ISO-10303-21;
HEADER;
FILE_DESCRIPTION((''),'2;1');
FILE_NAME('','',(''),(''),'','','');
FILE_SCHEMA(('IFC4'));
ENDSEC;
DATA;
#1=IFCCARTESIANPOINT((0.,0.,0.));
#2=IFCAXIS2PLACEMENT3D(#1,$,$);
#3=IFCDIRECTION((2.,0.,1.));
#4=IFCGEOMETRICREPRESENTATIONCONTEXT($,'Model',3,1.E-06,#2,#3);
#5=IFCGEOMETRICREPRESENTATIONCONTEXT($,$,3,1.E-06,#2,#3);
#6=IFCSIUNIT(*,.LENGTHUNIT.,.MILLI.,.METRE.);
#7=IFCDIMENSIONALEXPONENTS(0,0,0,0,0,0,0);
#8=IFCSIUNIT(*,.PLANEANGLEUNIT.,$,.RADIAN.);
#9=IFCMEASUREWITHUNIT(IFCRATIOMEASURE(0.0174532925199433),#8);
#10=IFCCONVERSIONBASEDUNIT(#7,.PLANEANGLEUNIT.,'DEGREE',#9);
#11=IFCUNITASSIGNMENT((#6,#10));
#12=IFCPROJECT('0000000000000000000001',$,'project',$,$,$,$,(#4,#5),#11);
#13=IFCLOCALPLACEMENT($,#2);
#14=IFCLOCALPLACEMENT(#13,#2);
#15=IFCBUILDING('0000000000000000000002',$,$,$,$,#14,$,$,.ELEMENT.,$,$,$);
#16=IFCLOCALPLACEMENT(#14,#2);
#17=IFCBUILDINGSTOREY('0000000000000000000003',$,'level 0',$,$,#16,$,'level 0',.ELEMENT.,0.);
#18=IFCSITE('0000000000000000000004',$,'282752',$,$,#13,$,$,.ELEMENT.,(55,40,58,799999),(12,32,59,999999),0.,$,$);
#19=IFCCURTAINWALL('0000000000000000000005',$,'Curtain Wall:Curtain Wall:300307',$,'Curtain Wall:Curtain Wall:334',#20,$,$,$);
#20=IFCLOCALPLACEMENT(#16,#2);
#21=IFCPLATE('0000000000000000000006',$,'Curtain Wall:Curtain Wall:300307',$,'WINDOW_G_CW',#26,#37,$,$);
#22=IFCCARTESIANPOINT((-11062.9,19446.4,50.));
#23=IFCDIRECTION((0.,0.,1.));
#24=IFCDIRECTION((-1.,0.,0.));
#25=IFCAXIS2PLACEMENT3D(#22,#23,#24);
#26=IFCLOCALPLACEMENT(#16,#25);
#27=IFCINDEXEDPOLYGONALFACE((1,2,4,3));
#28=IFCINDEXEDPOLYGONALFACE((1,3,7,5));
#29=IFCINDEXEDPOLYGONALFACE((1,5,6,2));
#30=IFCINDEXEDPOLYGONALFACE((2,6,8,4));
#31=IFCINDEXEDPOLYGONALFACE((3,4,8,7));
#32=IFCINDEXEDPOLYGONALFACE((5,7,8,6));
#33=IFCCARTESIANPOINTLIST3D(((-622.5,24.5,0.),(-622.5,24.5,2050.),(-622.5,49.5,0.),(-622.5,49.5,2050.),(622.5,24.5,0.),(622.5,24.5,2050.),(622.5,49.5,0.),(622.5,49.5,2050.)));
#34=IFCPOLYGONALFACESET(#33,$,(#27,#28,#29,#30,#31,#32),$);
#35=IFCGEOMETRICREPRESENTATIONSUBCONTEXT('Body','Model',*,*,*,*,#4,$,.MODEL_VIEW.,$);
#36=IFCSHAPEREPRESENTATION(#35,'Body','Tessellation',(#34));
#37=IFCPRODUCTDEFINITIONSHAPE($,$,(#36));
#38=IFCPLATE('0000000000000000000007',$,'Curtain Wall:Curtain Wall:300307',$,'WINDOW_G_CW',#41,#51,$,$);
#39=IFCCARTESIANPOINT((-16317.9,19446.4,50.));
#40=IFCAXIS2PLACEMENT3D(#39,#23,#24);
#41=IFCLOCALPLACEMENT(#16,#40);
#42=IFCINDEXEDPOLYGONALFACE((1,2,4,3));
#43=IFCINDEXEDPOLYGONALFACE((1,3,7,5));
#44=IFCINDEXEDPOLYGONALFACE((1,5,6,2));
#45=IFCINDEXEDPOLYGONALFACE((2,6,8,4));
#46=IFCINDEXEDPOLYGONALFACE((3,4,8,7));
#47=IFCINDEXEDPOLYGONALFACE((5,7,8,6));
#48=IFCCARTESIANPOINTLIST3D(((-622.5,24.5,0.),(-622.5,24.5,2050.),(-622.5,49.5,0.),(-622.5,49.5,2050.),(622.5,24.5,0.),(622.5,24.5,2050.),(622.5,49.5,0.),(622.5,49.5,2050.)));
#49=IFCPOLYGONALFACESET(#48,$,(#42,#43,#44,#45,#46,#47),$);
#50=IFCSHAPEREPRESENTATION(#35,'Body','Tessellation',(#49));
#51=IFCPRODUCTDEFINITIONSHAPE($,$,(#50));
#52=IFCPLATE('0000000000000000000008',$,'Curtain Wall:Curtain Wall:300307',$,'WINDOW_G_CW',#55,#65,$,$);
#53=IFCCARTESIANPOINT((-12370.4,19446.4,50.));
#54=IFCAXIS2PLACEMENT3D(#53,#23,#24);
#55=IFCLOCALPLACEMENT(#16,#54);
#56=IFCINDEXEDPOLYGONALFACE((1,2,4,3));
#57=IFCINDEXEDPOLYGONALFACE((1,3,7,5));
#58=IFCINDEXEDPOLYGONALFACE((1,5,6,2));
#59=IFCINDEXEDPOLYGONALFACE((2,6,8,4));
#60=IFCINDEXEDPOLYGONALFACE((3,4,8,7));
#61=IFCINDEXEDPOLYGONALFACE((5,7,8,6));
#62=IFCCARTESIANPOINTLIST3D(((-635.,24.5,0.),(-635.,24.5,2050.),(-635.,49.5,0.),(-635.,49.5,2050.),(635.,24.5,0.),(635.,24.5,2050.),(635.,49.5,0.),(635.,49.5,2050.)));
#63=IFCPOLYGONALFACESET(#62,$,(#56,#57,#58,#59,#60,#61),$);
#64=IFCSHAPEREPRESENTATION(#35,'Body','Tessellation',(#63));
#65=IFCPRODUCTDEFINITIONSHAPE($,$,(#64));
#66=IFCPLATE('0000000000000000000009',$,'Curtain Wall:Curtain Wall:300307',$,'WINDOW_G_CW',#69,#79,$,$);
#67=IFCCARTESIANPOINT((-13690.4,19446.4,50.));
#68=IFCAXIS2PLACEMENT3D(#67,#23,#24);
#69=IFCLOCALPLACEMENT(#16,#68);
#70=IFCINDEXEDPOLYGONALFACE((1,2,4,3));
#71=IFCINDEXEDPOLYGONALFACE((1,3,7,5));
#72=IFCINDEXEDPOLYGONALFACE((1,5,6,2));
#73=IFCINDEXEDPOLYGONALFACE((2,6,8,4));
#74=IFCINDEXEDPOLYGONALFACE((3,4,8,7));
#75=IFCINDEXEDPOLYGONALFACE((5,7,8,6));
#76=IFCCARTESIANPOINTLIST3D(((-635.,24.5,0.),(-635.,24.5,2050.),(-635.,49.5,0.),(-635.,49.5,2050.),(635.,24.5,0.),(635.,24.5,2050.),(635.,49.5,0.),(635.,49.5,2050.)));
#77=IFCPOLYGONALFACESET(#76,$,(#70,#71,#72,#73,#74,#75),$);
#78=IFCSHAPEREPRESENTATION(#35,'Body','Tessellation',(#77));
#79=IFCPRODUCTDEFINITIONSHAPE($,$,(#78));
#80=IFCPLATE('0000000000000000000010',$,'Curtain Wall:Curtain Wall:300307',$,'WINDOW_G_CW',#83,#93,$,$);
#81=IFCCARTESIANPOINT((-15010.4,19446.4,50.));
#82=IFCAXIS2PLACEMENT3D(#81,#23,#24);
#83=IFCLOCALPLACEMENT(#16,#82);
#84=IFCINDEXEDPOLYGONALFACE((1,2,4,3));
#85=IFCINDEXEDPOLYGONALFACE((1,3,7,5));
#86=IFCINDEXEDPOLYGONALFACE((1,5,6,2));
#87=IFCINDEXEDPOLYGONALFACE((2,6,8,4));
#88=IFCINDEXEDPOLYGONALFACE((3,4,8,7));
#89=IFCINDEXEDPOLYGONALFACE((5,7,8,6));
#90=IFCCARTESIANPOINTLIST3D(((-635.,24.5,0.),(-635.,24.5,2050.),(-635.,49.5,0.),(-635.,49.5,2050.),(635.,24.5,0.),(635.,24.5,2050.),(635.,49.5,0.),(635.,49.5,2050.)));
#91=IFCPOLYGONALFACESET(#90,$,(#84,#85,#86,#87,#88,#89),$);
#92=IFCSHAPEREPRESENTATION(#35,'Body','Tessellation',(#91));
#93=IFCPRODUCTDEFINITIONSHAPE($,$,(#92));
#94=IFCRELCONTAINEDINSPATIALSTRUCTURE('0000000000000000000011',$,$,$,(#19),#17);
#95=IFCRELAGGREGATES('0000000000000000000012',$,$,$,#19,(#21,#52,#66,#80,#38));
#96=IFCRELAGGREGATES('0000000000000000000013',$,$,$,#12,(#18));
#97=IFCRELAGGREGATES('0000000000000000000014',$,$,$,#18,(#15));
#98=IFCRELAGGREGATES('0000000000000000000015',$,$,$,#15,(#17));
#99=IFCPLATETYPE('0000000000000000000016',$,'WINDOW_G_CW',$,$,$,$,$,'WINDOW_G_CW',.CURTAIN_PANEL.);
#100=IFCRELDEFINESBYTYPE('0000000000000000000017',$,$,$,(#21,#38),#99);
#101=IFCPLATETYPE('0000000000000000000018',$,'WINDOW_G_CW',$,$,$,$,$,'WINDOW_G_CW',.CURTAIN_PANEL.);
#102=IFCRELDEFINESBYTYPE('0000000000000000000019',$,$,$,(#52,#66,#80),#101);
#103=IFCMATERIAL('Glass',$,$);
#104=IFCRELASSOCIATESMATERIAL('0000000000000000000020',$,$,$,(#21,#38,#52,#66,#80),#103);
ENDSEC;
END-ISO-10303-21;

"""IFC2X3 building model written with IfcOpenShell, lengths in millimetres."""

from ifc_helpers import new_model, entity, si_unit, converted_unit, direction, frame, origin, origin_2d_with_axis, place, context, subcontext, project, spatial, rectangle, extrude, source, transform, mapped, material, type_object, type_shapes, element, aggregate, save


model = new_model("IFC2X3")

# Units and contexts
model_context = context("Model", 3, precision=1e-06, world=origin(), true_north=direction((2.0, 0.0, 1.0)))
context_of_model = context(None, 3, precision=1e-06, world=origin(), true_north=direction((2.0, 0.0, 1.0)))
body_context = subcontext(model_context, "Body", "Model", "MODEL_VIEW")
ifc_project = project(units=[si_unit("LENGTHUNIT", "METRE", prefix="MILLI"), converted_unit("PLANEANGLEUNIT", "DEGREE", entity("IfcRatioMeasure", 0.0174532925199433), si_unit("PLANEANGLEUNIT", "RADIAN"), dimensions=[0, 0, 0, 0, 0, 0, 0])], contexts=[model_context, context_of_model])

# Site, building, storey
site_placement = place(None, origin())
site = spatial("IfcSite", under=ifc_project, at=site_placement, Name="282752", CompositionType="ELEMENT", RefLatitude=(55, 40, 58, 799999), RefLongitude=(12, 32, 59, 999999), RefElevation=0.0)
building_placement = place(site_placement, origin())
building = spatial("IfcBuilding", under=site, at=building_placement, CompositionType="ELEMENT")
storey_placement = place(building_placement, origin())
storey = spatial("IfcBuildingStorey", under=building, at=storey_placement, Name="level 0", LongName="level 0", CompositionType="ELEMENT", Elevation=0.0)

# Curtain wall, plates
curtain_wall_placement = place(storey_placement, origin())
curtain_wall = element("IfcCurtainWall", 1, at=curtain_wall_placement, inside=storey, Name="Curtain Wall:Curtain Wall:300307", ObjectType="Curtain Wall:Curtain Wall:334")
ifc_material_1 = material(Name="Glass")
plate_type_1 = type_object("IfcPlateType", Name="WINDOW_G_CW", ElementType="WINDOW_G_CW", PredefinedType="CURTAIN_PANEL")
shared_shape_1 = source(origin(), body_context, "Body", "SweptSolid", [
    extrude(rectangle(XDim=25.0, YDim=1245.0, at=origin_2d_with_axis()), frame((0.0, 37.0, 0.0), z_axis=(0.0, 0.0, 1.0), x_axis=(0.0, 1.0, 0.0)), (0.0, 0.0, 1.0), 2050.0),
])
type_shapes(plate_type_1, [shared_shape_1])
plate_1_placement = place(storey_placement, frame((-11062.9, 19446.4, 50.0), z_axis=(0.0, 0.0, 1.0), x_axis=(-1.0, 0.0, 0.0)))
plate_1 = element("IfcPlate", 2, at=plate_1_placement, type_object=plate_type_1, material=ifc_material_1, Name="Curtain Wall:Curtain Wall:300307", ObjectType="WINDOW_G_CW", context=body_context, shape_type="MappedRepresentation", body=[
    mapped(shared_shape_1, transform((0.0, 0.0, 0.0), scale=1.0)),
])
plate_2_placement = place(storey_placement, frame((-16317.9, 19446.4, 50.0), z_axis=(0.0, 0.0, 1.0), x_axis=(-1.0, 0.0, 0.0)))
plate_2 = element("IfcPlate", 3, at=plate_2_placement, type_object=plate_type_1, material=ifc_material_1, Name="Curtain Wall:Curtain Wall:300307", ObjectType="WINDOW_G_CW", context=body_context, shape_type="MappedRepresentation", body=[
    mapped(shared_shape_1, transform((0.0, 0.0, 0.0), scale=1.0)),
])
plate_type_2 = type_object("IfcPlateType", Name="WINDOW_G_CW", ElementType="WINDOW_G_CW", PredefinedType="CURTAIN_PANEL")
shared_shape_2 = source(origin(), body_context, "Body", "SweptSolid", [
    extrude(rectangle(XDim=25.0, YDim=1270.0, at=origin_2d_with_axis()), frame((0.0, 37.0, 0.0), z_axis=(0.0, 0.0, 1.0), x_axis=(0.0, 1.0, 0.0)), (0.0, 0.0, 1.0), 2050.0),
])
type_shapes(plate_type_2, [shared_shape_2])
plate_3_placement = place(storey_placement, frame((-12370.4, 19446.4, 50.0), z_axis=(0.0, 0.0, 1.0), x_axis=(-1.0, 0.0, 0.0)))
plate_3 = element("IfcPlate", 4, at=plate_3_placement, type_object=plate_type_2, material=ifc_material_1, Name="Curtain Wall:Curtain Wall:300307", ObjectType="WINDOW_G_CW", context=body_context, shape_type="MappedRepresentation", body=[
    mapped(shared_shape_2, transform((0.0, 0.0, 0.0), scale=1.0)),
])
plate_4_placement = place(storey_placement, frame((-13690.4, 19446.4, 50.0), z_axis=(0.0, 0.0, 1.0), x_axis=(-1.0, 0.0, 0.0)))
plate_4 = element("IfcPlate", 5, at=plate_4_placement, type_object=plate_type_2, material=ifc_material_1, Name="Curtain Wall:Curtain Wall:300307", ObjectType="WINDOW_G_CW", context=body_context, shape_type="MappedRepresentation", body=[
    mapped(shared_shape_2, transform((0.0, 0.0, 0.0), scale=1.0)),
])
plate_5_placement = place(storey_placement, frame((-15010.4, 19446.4, 50.0), z_axis=(0.0, 0.0, 1.0), x_axis=(-1.0, 0.0, 0.0)))
plate_5 = element("IfcPlate", 6, at=plate_5_placement, type_object=plate_type_2, material=ifc_material_1, Name="Curtain Wall:Curtain Wall:300307", ObjectType="WINDOW_G_CW", context=body_context, shape_type="MappedRepresentation", body=[
    mapped(shared_shape_2, transform((0.0, 0.0, 0.0), scale=1.0)),
])
aggregate(curtain_wall, [plate_1, plate_3, plate_4, plate_5, plate_2])

save(model, "model.ifc")
